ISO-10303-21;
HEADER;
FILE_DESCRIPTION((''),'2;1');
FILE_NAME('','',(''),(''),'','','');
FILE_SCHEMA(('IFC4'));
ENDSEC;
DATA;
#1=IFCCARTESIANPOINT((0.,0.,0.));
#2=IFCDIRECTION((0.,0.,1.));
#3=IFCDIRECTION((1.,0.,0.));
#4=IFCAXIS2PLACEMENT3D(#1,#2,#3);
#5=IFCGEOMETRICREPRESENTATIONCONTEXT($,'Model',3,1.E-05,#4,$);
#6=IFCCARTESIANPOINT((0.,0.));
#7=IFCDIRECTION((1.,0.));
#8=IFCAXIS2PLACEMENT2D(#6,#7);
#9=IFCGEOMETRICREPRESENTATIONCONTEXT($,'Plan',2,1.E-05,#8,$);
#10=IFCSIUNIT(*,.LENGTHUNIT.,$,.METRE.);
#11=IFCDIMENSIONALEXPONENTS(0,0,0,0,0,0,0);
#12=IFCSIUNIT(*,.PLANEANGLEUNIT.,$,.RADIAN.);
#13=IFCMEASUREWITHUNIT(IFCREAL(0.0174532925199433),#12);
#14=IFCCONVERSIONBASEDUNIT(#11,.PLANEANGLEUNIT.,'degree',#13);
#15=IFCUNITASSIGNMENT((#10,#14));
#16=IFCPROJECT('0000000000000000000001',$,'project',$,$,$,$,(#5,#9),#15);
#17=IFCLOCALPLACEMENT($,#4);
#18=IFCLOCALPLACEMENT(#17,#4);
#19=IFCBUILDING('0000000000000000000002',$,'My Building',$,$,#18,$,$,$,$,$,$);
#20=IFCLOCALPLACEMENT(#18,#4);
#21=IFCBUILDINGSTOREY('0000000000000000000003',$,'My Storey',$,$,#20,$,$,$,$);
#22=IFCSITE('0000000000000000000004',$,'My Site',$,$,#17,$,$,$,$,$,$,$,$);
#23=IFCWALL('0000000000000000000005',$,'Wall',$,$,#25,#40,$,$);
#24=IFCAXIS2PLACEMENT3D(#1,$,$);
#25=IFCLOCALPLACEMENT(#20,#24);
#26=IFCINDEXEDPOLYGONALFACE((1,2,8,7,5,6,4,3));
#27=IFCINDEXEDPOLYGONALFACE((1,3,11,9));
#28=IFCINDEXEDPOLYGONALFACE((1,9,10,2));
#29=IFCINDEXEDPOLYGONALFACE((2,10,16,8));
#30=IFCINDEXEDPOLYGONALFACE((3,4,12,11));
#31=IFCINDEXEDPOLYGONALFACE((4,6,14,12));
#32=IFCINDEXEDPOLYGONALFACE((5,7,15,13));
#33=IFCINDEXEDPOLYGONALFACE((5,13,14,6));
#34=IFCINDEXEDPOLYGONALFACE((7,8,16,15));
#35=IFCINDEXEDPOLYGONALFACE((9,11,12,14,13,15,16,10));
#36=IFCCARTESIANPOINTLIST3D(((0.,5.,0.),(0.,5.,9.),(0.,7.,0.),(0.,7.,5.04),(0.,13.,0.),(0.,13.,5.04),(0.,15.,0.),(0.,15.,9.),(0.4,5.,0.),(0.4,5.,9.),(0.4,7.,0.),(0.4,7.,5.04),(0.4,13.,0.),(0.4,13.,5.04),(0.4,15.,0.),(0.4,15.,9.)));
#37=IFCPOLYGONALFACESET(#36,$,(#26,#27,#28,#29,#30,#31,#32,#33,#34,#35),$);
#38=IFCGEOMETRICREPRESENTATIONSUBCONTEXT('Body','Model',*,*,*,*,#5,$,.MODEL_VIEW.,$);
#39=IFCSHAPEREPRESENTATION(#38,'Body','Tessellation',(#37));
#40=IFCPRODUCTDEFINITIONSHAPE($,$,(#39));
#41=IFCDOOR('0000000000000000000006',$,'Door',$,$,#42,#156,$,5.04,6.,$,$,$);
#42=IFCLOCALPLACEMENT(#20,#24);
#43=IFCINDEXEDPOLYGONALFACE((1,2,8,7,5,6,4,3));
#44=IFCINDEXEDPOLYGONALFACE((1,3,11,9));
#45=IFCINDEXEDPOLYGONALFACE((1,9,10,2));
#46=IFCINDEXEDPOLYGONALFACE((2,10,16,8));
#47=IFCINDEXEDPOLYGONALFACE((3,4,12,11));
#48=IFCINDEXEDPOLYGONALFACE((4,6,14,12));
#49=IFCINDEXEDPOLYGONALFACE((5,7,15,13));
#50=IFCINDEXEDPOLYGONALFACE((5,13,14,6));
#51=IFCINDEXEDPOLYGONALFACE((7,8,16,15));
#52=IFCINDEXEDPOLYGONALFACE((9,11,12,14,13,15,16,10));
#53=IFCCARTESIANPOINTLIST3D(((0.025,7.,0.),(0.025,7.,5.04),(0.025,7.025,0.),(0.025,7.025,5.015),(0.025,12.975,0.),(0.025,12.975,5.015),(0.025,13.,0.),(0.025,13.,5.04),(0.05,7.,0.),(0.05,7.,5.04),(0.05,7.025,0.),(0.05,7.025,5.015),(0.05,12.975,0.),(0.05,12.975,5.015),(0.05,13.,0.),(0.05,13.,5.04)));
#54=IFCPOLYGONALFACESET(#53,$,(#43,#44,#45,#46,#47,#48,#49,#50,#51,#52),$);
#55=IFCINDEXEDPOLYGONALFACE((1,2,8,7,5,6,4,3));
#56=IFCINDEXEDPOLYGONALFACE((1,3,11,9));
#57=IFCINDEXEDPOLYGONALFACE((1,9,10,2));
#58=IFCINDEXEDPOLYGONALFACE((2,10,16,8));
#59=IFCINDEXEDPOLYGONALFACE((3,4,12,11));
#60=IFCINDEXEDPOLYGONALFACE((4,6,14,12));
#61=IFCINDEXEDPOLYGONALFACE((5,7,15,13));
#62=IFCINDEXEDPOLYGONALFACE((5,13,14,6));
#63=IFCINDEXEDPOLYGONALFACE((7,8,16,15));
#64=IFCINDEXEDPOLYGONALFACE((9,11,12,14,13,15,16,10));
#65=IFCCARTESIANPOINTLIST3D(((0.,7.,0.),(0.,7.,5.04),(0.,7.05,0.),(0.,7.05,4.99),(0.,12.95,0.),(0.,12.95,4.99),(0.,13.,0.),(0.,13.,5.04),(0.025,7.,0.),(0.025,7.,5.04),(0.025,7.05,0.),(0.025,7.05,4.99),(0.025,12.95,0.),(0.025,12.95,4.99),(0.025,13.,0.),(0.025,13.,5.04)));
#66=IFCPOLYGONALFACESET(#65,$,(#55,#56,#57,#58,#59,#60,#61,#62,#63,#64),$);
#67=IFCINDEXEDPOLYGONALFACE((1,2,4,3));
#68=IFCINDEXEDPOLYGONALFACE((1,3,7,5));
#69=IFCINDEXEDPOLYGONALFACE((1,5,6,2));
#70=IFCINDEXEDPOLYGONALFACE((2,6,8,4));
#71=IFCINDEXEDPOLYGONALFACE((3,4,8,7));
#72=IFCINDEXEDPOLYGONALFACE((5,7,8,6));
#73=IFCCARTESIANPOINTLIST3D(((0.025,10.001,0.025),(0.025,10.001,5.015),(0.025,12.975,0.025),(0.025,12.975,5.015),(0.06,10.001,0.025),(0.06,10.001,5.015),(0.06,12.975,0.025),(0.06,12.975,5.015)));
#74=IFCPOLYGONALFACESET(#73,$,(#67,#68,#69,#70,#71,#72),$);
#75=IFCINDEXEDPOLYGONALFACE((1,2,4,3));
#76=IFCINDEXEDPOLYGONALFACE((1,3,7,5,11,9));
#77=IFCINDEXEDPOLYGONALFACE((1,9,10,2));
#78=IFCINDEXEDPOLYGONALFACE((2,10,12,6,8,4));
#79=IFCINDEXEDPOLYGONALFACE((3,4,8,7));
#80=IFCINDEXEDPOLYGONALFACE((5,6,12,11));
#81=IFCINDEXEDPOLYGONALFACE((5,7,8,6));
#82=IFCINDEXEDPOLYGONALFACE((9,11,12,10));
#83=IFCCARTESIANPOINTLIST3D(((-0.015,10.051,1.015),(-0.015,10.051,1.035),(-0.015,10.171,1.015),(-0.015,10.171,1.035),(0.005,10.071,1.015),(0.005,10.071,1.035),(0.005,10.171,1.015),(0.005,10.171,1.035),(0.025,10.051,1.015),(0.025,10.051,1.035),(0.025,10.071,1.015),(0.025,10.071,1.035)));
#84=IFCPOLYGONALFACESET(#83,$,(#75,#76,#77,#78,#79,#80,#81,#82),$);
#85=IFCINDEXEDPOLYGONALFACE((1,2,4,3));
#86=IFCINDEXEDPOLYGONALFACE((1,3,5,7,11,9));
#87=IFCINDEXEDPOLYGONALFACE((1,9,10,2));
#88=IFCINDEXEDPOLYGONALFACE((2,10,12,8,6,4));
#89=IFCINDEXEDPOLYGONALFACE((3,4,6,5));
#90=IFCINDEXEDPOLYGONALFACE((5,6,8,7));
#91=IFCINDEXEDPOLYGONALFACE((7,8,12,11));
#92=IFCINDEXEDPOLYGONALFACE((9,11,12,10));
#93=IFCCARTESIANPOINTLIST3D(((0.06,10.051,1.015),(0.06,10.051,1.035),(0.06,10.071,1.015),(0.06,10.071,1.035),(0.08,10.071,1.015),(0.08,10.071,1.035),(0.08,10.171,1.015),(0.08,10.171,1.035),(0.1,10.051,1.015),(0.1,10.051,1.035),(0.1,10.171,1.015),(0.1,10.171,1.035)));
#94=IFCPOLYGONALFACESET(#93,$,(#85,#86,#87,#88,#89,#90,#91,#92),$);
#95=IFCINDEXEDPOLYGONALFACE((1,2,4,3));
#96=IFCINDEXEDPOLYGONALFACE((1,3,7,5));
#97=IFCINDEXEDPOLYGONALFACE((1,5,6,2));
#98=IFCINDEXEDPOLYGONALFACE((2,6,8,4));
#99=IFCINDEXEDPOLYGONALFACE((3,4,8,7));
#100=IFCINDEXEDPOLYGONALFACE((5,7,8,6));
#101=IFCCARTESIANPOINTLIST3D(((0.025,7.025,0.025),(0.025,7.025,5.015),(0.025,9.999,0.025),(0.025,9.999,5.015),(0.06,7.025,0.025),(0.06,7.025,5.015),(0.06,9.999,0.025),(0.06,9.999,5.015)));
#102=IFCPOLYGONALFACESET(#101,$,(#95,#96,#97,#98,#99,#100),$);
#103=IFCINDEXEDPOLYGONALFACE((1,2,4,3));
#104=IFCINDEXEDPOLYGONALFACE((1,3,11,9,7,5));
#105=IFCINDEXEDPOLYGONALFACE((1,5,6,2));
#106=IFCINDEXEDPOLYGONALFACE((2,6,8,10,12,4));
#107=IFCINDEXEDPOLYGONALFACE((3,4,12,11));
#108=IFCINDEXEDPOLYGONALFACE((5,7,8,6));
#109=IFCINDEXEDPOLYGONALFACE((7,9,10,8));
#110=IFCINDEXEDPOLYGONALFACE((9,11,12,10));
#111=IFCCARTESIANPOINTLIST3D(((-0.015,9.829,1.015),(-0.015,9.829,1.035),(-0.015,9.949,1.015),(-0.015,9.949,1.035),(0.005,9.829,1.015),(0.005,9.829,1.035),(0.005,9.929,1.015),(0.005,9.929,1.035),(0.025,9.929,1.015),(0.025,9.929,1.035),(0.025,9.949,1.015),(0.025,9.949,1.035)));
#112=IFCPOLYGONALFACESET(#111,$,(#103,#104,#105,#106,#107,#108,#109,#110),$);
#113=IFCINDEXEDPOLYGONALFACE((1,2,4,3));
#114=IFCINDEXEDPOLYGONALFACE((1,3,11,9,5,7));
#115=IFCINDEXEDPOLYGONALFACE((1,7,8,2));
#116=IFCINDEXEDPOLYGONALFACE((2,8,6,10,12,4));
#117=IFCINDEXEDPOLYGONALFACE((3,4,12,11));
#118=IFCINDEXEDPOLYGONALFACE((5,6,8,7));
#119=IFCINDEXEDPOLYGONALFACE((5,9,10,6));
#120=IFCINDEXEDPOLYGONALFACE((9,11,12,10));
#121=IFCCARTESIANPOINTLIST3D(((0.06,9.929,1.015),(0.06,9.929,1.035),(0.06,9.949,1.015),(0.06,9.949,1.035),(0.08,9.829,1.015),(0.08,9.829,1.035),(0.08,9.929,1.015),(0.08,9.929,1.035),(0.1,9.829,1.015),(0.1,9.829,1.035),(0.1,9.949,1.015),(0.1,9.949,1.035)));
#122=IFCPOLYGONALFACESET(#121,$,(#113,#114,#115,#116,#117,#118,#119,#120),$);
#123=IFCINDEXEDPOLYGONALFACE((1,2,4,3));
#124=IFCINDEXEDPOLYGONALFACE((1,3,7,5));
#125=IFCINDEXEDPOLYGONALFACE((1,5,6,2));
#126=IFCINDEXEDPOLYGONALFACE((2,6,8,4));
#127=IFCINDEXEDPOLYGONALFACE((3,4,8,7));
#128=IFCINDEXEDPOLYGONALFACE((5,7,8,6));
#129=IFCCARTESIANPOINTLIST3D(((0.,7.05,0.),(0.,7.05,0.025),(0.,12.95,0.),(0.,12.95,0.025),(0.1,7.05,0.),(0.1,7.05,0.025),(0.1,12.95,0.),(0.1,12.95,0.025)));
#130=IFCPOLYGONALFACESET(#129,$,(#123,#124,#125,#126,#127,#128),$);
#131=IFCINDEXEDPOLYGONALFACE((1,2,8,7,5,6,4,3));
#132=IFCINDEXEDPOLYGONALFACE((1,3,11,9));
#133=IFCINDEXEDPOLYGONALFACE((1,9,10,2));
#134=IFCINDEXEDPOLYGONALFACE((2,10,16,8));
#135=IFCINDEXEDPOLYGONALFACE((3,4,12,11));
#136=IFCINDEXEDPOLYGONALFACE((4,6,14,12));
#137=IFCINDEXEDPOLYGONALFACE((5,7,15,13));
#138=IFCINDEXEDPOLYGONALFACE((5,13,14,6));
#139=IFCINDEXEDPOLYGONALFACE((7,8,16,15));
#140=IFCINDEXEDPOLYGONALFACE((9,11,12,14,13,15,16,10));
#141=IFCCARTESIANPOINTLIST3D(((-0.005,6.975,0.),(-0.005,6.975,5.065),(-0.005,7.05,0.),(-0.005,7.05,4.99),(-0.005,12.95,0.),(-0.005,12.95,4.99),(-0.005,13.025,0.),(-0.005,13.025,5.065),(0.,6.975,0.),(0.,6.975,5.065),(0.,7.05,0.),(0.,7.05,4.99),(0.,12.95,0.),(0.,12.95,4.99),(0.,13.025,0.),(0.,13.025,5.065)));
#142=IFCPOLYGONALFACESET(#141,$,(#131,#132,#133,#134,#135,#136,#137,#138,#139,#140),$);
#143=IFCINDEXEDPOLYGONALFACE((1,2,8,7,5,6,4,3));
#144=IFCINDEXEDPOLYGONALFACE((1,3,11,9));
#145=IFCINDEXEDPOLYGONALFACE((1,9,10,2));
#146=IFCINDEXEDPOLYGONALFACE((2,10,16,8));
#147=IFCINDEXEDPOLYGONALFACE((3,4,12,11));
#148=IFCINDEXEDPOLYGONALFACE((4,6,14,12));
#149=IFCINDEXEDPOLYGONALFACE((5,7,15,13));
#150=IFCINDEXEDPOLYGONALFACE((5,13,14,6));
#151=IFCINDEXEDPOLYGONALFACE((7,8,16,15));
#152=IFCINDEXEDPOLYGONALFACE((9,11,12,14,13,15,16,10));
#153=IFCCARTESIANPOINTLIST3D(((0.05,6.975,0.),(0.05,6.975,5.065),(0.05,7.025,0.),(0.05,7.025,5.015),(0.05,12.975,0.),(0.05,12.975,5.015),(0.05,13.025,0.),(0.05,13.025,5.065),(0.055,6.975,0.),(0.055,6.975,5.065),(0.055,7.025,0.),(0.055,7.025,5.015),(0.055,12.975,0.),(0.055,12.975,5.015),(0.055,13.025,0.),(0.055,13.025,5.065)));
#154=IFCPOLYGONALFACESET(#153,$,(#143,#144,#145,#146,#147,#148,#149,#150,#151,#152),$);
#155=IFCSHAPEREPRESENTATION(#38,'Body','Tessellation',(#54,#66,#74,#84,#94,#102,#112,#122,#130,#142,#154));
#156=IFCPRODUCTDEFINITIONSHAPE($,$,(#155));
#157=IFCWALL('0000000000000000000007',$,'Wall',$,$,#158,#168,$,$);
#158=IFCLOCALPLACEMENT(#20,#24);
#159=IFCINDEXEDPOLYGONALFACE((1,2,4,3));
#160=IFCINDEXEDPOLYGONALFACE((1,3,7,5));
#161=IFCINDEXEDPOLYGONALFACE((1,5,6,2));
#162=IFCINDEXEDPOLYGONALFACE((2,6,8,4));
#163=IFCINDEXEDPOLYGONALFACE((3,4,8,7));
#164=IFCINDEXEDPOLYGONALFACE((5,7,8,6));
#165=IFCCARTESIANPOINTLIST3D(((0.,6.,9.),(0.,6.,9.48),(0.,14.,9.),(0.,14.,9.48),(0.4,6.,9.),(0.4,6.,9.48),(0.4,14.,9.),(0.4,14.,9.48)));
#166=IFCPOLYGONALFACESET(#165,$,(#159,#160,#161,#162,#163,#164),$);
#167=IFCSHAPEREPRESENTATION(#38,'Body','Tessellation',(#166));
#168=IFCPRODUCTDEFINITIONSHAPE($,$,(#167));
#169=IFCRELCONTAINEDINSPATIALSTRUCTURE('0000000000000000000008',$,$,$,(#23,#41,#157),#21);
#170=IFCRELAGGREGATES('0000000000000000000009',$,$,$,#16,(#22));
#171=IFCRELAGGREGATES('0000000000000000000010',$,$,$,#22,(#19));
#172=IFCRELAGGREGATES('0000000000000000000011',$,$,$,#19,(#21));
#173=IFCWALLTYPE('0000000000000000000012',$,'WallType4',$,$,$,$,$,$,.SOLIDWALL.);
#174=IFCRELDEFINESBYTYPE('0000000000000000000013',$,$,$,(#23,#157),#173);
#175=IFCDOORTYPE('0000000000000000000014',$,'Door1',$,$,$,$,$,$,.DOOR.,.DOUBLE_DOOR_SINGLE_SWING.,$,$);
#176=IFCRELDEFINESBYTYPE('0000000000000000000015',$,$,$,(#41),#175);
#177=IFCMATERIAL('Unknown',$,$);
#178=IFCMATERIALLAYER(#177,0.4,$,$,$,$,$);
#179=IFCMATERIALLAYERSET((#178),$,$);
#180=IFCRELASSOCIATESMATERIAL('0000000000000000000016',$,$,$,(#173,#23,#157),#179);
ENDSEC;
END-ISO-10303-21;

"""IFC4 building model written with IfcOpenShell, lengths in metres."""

from ifc_helpers import new_model, entity, si_unit, converted_unit, frame, origin_with_axes, origin_2d_with_axis, place, context, subcontext, project, spatial, line, indexed_curve, outline, extrude, shape, source, transform, mapped, material, layer, layer_set, layer_usage, type_object, type_shapes, element, fill, save


model = new_model("IFC4")

# Units and contexts
model_context = context("Model", 3, precision=1e-05, world=origin_with_axes())
plan_context = context("Plan", 2, precision=1e-05, world=origin_2d_with_axis())
body_context_1 = subcontext(model_context, "Body", "Model", "MODEL_VIEW")
body_context_2 = subcontext(plan_context, "Body", "Plan", "PLAN_VIEW")
ifc_project = project(units=[si_unit("LENGTHUNIT", "METRE"), converted_unit("PLANEANGLEUNIT", "degree", entity("IfcReal", 0.0174532925199433), si_unit("PLANEANGLEUNIT", "RADIAN"), dimensions=[0, 0, 0, 0, 0, 0, 0])], contexts=[model_context, plan_context])

# Site, building, storey
site_placement = place(None, origin_with_axes())
site = spatial("IfcSite", under=ifc_project, at=site_placement, Name="My Site")
building_placement = place(site_placement, origin_with_axes())
building = spatial("IfcBuilding", under=site, at=building_placement, Name="My Building")
storey_placement = place(building_placement, origin_with_axes())
storey = spatial("IfcBuildingStorey", under=building, at=storey_placement, Name="My Storey")

# Shared definitions
ifc_material = material(Name="Unknown")
ifc_layer = layer(ifc_material, 0.4)
ifc_layer_set = layer_set([ifc_layer])
wall_type = type_object("IfcWallType", Name="WallType4", PredefinedType="SOLIDWALL", material=ifc_layer_set)

# Wall, opening, door
ifc_layer_usage_1 = layer_usage(ifc_layer_set, "AXIS2", "POSITIVE", 0.0)
wall_1_placement = place(storey_placement, frame((0.0, 15.0, 0.0), z_axis=(0.0, 0.0, 1.0), x_axis=(0.0, -1.0, 0.0)))
wall_1 = element("IfcWall", 1, at=wall_1_placement, inside=storey, type_object=wall_type, material=ifc_layer_usage_1, Name="Wall", context=body_context_1, shape_type="SweptSolid", body=[
    extrude(outline(indexed_curve([(0.0, 0.0), (0.0, 0.4), (10.0, 0.4), (10.0, 0.0), (0.0, 0.0)], self_intersect=False)), origin_with_axes(), (0.0, 0.0, 1.0), 9.0),
])
shared_shape_1 = source(origin_with_axes(), body_context_1, "Body", "SweptSolid", [
    extrude(outline(indexed_curve([(0.0, 0.0), (6.0, 0.0), (6.0, 5.04), (0.0, 5.04)], segments=[line(1, 2, 3, 4, 1)])), frame((0.0, -0.1, 0.0), z_axis=(0.0, -1.0, 0.0), x_axis=(1.0, 0.0, 0.0)), (0.0, 0.0, -1.0), 0.6),
])
opening_1_placement = place(wall_1_placement, frame((2.0, 0.0, 0.0), z_axis=(0.0, 0.0, 1.0), x_axis=(1.0, 0.0, 0.0)))
opening_1 = element("IfcOpeningElement", 2, at=opening_1_placement, cuts=wall_1, PredefinedType="OPENING", context=body_context_1, shape_type="MappedRepresentation", body=[
    mapped(shared_shape_1, transform((0.0, 0.0, 0.0), x_axis=(1.0, 0.0, 0.0), y_axis=(0.0, 1.0, 0.0), z_axis=(0.0, 0.0, 1.0), scale=1.0)),
])
door_type_1 = type_object("IfcDoorType", Name="Door1", OperationType="DOUBLE_DOOR_SINGLE_SWING", PredefinedType="DOOR")
shared_shape_2 = source(origin_with_axes(), body_context_1, "Body", "SweptSolid", [
    extrude(outline(indexed_curve([(0.0, 0.0), (0.0, 5.04), (6.0, 5.04), (6.0, 0.0), (5.975, 0.0), (5.975, 5.015), (0.025, 5.015), (0.025, 0.0)], segments=[line(1, 2, 3, 4, 5, 6, 7, 8, 1)])), frame((0.0, 0.025, 0.0), z_axis=(0.0, -1.0, 0.0), x_axis=(1.0, 0.0, 0.0)), (0.0, 0.0, -1.0), 0.025),
    extrude(outline(indexed_curve([(0.0, 0.0), (0.0, 5.04), (6.0, 5.04), (6.0, 0.0), (5.95, 0.0), (5.95, 4.99), (0.05, 4.99), (0.05, 0.0)], segments=[line(1, 2, 3, 4, 5, 6, 7, 8, 1)])), frame((0.0, 0.0, 0.0), z_axis=(0.0, -1.0, 0.0), x_axis=(1.0, 0.0, 0.0)), (0.0, 0.0, -1.0), 0.025),
    extrude(outline(indexed_curve([(0.0, 0.0), (2.974, 0.0), (2.974, 0.035), (0.0, 0.035)], segments=[line(1, 2, 3, 4, 1)])), frame((0.025, 0.025, 0.025), z_axis=(0.0, 0.0, 1.0), x_axis=(1.0, 0.0, 0.0)), (0.0, 0.0, 1.0), 4.99),
    extrude(outline(indexed_curve([(0.0, 0.0), (0.0, -0.04), (-0.12, -0.04), (-0.12, -0.02), (-0.02, -0.02), (-0.02, 0.0)], segments=[line(1, 2, 3, 4, 5, 6, 1)])), frame((2.949, 0.025, 1.015), z_axis=(0.0, 0.0, 1.0), x_axis=(1.0, 0.0, 0.0)), (0.0, 0.0, 1.0), 0.02),
    extrude(outline(indexed_curve([(0.0, 0.0), (0.0, 0.04), (-0.12, 0.04), (-0.12, 0.02), (-0.02, 0.02), (-0.02, 0.0)], segments=[line(1, 2, 3, 4, 5, 6, 1)])), frame((2.949, 0.06, 1.015), z_axis=(0.0, 0.0, 1.0), x_axis=(1.0, 0.0, 0.0)), (0.0, 0.0, 1.0), 0.02),
    extrude(outline(indexed_curve([(0.0, 0.0), (-2.974, 0.0), (-2.974, 0.035), (0.0, 0.035)], segments=[line(1, 2, 3, 4, 1)])), frame((5.975, 0.025, 0.025), z_axis=(0.0, 0.0, 1.0), x_axis=(1.0, 0.0, 0.0)), (0.0, 0.0, 1.0), 4.99),
    extrude(outline(indexed_curve([(0.0, 0.0), (0.0, -0.04), (0.12, -0.04), (0.12, -0.02), (0.02, -0.02), (0.02, 0.0)], segments=[line(1, 2, 3, 4, 5, 6, 1)])), frame((3.051, 0.025, 1.015), z_axis=(0.0, 0.0, 1.0), x_axis=(1.0, 0.0, 0.0)), (0.0, 0.0, 1.0), 0.02),
    extrude(outline(indexed_curve([(0.0, 0.0), (0.0, 0.04), (0.12, 0.04), (0.12, 0.02), (0.02, 0.02), (0.02, 0.0)], segments=[line(1, 2, 3, 4, 5, 6, 1)])), frame((3.051, 0.06, 1.015), z_axis=(0.0, 0.0, 1.0), x_axis=(1.0, 0.0, 0.0)), (0.0, 0.0, 1.0), 0.02),
    extrude(outline(indexed_curve([(0.0, 0.0), (5.9, 0.0), (5.9, 0.1), (0.0, 0.1)], segments=[line(1, 2, 3, 4, 1)])), frame((0.05, 0.0, 0.0), z_axis=(0.0, 0.0, 1.0), x_axis=(1.0, 0.0, 0.0)), (0.0, 0.0, 1.0), 0.025),
    extrude(outline(indexed_curve([(0.0, 0.0), (0.0, 5.065), (6.05, 5.065), (6.05, 0.0), (5.975, 0.0), (5.975, 4.99), (0.075, 4.99), (0.075, 0.0)], segments=[line(1, 2, 3, 4, 5, 6, 7, 8, 1)])), frame((-0.025, -0.005, 0.0), z_axis=(0.0, -1.0, 0.0), x_axis=(1.0, 0.0, 0.0)), (0.0, 0.0, -1.0), 0.005),
    extrude(outline(indexed_curve([(0.0, 0.0), (0.0, 5.065), (6.05, 5.065), (6.05, 0.0), (6.0, 0.0), (6.0, 5.015), (0.05, 5.015), (0.05, 0.0)], segments=[line(1, 2, 3, 4, 5, 6, 7, 8, 1)])), frame((-0.025, 0.05, 0.0), z_axis=(0.0, -1.0, 0.0), x_axis=(1.0, 0.0, 0.0)), (0.0, 0.0, -1.0), 0.005),
])
shared_shape_3 = source(origin_with_axes(), body_context_2, "Body", "Curve2D", [
    entity("IfcIndexedPolyCurve", entity("IfcCartesianPointList2D", [[0.0, 0.0], [0.0, 0.05], [0.025, 0.05], [0.025, 0.025], [0.05, 0.025], [0.05, 0.0]]), [entity("IfcLineIndex", [1, 2, 3, 4, 5, 6, 1])]),
    entity("IfcIndexedPolyCurve", entity("IfcCartesianPointList2D", [[6.0, 0.0], [6.0, 0.05], [5.975, 0.05], [5.975, 0.025], [5.95, 0.025], [5.95, 0.0]]), [entity("IfcLineIndex", [1, 2, 3, 4, 5, 6, 1])]),
    entity("IfcTrimmedCurve", entity("IfcEllipse", entity("IfcAxis2Placement2D", entity("IfcCartesianPoint", [0.06, 0.05]), entity("IfcDirection", [1.0, 0.0])), 2.94, 2.975), [entity("IfcCartesianPoint", [3.0, 0.05])], [entity("IfcCartesianPoint", [0.06, 3.025])], True, "CARTESIAN"),
    entity("IfcIndexedPolyCurve", entity("IfcCartesianPointList2D", [[0.025, 0.05], [0.06, 0.05], [0.06, 3.025], [0.025, 3.025]]), [entity("IfcLineIndex", [1, 2, 3, 4, 1])]),
    entity("IfcTrimmedCurve", entity("IfcEllipse", entity("IfcAxis2Placement2D", entity("IfcCartesianPoint", [5.94, 0.05]), entity("IfcDirection", [1.0, 0.0])), 2.94, 2.975), [entity("IfcCartesianPoint", [5.94, 3.025])], [entity("IfcCartesianPoint", [3.0, 0.05])], True, "CARTESIAN"),
    entity("IfcIndexedPolyCurve", entity("IfcCartesianPointList2D", [[5.975, 0.05], [5.94, 0.05], [5.94, 3.025], [5.975, 3.025]]), [entity("IfcLineIndex", [1, 2, 3, 4, 1])]),
])
type_shapes(door_type_1, [shared_shape_2, shared_shape_3])
door_1_placement = place(opening_1_placement, frame((0.0, 0.0, 0.0), z_axis=(0.0, 0.0, 1.0), x_axis=(1.0, 0.0, 0.0)))
door_1 = element("IfcDoor", 3, at=door_1_placement, inside=storey, type_object=door_type_1, Name="Door", OverallHeight=5.04, OverallWidth=6.0, shapes=[
    shape(body_context_1, "Body", "MappedRepresentation", [mapped(shared_shape_2, transform((0.0, 0.0, 0.0), x_axis=(1.0, 0.0, 0.0), y_axis=(0.0, 1.0, 0.0), z_axis=(0.0, 0.0, 1.0), scale=1.0))]),
    shape(body_context_2, "Body", "MappedRepresentation", [mapped(shared_shape_3, transform((0.0, 0.0, 0.0), x_axis=(1.0, 0.0, 0.0), y_axis=(0.0, 1.0, 0.0), z_axis=(0.0, 0.0, 1.0), scale=1.0))]),
])
fill(opening_1, door_1)

# Wall
ifc_layer_usage_2 = layer_usage(ifc_layer_set, "AXIS2", "POSITIVE", 0.0)
wall_2_placement = place(storey_placement, frame((0.4, 6.0, 9.0), z_axis=(0.0, 0.0, 1.0), x_axis=(0.0, 1.0, 0.0)))
element("IfcWall", 4, at=wall_2_placement, inside=storey, type_object=wall_type, material=ifc_layer_usage_2, Name="Wall", context=body_context_1, shape_type="SweptSolid", body=[
    extrude(outline(indexed_curve([(0.0, 0.0), (0.0, 0.4), (8.0, 0.4), (8.0, 0.0), (0.0, 0.0)], self_intersect=False)), origin_with_axes(), (0.0, 0.0, 1.0), 0.48),
])

save(model, "model.ifc")
